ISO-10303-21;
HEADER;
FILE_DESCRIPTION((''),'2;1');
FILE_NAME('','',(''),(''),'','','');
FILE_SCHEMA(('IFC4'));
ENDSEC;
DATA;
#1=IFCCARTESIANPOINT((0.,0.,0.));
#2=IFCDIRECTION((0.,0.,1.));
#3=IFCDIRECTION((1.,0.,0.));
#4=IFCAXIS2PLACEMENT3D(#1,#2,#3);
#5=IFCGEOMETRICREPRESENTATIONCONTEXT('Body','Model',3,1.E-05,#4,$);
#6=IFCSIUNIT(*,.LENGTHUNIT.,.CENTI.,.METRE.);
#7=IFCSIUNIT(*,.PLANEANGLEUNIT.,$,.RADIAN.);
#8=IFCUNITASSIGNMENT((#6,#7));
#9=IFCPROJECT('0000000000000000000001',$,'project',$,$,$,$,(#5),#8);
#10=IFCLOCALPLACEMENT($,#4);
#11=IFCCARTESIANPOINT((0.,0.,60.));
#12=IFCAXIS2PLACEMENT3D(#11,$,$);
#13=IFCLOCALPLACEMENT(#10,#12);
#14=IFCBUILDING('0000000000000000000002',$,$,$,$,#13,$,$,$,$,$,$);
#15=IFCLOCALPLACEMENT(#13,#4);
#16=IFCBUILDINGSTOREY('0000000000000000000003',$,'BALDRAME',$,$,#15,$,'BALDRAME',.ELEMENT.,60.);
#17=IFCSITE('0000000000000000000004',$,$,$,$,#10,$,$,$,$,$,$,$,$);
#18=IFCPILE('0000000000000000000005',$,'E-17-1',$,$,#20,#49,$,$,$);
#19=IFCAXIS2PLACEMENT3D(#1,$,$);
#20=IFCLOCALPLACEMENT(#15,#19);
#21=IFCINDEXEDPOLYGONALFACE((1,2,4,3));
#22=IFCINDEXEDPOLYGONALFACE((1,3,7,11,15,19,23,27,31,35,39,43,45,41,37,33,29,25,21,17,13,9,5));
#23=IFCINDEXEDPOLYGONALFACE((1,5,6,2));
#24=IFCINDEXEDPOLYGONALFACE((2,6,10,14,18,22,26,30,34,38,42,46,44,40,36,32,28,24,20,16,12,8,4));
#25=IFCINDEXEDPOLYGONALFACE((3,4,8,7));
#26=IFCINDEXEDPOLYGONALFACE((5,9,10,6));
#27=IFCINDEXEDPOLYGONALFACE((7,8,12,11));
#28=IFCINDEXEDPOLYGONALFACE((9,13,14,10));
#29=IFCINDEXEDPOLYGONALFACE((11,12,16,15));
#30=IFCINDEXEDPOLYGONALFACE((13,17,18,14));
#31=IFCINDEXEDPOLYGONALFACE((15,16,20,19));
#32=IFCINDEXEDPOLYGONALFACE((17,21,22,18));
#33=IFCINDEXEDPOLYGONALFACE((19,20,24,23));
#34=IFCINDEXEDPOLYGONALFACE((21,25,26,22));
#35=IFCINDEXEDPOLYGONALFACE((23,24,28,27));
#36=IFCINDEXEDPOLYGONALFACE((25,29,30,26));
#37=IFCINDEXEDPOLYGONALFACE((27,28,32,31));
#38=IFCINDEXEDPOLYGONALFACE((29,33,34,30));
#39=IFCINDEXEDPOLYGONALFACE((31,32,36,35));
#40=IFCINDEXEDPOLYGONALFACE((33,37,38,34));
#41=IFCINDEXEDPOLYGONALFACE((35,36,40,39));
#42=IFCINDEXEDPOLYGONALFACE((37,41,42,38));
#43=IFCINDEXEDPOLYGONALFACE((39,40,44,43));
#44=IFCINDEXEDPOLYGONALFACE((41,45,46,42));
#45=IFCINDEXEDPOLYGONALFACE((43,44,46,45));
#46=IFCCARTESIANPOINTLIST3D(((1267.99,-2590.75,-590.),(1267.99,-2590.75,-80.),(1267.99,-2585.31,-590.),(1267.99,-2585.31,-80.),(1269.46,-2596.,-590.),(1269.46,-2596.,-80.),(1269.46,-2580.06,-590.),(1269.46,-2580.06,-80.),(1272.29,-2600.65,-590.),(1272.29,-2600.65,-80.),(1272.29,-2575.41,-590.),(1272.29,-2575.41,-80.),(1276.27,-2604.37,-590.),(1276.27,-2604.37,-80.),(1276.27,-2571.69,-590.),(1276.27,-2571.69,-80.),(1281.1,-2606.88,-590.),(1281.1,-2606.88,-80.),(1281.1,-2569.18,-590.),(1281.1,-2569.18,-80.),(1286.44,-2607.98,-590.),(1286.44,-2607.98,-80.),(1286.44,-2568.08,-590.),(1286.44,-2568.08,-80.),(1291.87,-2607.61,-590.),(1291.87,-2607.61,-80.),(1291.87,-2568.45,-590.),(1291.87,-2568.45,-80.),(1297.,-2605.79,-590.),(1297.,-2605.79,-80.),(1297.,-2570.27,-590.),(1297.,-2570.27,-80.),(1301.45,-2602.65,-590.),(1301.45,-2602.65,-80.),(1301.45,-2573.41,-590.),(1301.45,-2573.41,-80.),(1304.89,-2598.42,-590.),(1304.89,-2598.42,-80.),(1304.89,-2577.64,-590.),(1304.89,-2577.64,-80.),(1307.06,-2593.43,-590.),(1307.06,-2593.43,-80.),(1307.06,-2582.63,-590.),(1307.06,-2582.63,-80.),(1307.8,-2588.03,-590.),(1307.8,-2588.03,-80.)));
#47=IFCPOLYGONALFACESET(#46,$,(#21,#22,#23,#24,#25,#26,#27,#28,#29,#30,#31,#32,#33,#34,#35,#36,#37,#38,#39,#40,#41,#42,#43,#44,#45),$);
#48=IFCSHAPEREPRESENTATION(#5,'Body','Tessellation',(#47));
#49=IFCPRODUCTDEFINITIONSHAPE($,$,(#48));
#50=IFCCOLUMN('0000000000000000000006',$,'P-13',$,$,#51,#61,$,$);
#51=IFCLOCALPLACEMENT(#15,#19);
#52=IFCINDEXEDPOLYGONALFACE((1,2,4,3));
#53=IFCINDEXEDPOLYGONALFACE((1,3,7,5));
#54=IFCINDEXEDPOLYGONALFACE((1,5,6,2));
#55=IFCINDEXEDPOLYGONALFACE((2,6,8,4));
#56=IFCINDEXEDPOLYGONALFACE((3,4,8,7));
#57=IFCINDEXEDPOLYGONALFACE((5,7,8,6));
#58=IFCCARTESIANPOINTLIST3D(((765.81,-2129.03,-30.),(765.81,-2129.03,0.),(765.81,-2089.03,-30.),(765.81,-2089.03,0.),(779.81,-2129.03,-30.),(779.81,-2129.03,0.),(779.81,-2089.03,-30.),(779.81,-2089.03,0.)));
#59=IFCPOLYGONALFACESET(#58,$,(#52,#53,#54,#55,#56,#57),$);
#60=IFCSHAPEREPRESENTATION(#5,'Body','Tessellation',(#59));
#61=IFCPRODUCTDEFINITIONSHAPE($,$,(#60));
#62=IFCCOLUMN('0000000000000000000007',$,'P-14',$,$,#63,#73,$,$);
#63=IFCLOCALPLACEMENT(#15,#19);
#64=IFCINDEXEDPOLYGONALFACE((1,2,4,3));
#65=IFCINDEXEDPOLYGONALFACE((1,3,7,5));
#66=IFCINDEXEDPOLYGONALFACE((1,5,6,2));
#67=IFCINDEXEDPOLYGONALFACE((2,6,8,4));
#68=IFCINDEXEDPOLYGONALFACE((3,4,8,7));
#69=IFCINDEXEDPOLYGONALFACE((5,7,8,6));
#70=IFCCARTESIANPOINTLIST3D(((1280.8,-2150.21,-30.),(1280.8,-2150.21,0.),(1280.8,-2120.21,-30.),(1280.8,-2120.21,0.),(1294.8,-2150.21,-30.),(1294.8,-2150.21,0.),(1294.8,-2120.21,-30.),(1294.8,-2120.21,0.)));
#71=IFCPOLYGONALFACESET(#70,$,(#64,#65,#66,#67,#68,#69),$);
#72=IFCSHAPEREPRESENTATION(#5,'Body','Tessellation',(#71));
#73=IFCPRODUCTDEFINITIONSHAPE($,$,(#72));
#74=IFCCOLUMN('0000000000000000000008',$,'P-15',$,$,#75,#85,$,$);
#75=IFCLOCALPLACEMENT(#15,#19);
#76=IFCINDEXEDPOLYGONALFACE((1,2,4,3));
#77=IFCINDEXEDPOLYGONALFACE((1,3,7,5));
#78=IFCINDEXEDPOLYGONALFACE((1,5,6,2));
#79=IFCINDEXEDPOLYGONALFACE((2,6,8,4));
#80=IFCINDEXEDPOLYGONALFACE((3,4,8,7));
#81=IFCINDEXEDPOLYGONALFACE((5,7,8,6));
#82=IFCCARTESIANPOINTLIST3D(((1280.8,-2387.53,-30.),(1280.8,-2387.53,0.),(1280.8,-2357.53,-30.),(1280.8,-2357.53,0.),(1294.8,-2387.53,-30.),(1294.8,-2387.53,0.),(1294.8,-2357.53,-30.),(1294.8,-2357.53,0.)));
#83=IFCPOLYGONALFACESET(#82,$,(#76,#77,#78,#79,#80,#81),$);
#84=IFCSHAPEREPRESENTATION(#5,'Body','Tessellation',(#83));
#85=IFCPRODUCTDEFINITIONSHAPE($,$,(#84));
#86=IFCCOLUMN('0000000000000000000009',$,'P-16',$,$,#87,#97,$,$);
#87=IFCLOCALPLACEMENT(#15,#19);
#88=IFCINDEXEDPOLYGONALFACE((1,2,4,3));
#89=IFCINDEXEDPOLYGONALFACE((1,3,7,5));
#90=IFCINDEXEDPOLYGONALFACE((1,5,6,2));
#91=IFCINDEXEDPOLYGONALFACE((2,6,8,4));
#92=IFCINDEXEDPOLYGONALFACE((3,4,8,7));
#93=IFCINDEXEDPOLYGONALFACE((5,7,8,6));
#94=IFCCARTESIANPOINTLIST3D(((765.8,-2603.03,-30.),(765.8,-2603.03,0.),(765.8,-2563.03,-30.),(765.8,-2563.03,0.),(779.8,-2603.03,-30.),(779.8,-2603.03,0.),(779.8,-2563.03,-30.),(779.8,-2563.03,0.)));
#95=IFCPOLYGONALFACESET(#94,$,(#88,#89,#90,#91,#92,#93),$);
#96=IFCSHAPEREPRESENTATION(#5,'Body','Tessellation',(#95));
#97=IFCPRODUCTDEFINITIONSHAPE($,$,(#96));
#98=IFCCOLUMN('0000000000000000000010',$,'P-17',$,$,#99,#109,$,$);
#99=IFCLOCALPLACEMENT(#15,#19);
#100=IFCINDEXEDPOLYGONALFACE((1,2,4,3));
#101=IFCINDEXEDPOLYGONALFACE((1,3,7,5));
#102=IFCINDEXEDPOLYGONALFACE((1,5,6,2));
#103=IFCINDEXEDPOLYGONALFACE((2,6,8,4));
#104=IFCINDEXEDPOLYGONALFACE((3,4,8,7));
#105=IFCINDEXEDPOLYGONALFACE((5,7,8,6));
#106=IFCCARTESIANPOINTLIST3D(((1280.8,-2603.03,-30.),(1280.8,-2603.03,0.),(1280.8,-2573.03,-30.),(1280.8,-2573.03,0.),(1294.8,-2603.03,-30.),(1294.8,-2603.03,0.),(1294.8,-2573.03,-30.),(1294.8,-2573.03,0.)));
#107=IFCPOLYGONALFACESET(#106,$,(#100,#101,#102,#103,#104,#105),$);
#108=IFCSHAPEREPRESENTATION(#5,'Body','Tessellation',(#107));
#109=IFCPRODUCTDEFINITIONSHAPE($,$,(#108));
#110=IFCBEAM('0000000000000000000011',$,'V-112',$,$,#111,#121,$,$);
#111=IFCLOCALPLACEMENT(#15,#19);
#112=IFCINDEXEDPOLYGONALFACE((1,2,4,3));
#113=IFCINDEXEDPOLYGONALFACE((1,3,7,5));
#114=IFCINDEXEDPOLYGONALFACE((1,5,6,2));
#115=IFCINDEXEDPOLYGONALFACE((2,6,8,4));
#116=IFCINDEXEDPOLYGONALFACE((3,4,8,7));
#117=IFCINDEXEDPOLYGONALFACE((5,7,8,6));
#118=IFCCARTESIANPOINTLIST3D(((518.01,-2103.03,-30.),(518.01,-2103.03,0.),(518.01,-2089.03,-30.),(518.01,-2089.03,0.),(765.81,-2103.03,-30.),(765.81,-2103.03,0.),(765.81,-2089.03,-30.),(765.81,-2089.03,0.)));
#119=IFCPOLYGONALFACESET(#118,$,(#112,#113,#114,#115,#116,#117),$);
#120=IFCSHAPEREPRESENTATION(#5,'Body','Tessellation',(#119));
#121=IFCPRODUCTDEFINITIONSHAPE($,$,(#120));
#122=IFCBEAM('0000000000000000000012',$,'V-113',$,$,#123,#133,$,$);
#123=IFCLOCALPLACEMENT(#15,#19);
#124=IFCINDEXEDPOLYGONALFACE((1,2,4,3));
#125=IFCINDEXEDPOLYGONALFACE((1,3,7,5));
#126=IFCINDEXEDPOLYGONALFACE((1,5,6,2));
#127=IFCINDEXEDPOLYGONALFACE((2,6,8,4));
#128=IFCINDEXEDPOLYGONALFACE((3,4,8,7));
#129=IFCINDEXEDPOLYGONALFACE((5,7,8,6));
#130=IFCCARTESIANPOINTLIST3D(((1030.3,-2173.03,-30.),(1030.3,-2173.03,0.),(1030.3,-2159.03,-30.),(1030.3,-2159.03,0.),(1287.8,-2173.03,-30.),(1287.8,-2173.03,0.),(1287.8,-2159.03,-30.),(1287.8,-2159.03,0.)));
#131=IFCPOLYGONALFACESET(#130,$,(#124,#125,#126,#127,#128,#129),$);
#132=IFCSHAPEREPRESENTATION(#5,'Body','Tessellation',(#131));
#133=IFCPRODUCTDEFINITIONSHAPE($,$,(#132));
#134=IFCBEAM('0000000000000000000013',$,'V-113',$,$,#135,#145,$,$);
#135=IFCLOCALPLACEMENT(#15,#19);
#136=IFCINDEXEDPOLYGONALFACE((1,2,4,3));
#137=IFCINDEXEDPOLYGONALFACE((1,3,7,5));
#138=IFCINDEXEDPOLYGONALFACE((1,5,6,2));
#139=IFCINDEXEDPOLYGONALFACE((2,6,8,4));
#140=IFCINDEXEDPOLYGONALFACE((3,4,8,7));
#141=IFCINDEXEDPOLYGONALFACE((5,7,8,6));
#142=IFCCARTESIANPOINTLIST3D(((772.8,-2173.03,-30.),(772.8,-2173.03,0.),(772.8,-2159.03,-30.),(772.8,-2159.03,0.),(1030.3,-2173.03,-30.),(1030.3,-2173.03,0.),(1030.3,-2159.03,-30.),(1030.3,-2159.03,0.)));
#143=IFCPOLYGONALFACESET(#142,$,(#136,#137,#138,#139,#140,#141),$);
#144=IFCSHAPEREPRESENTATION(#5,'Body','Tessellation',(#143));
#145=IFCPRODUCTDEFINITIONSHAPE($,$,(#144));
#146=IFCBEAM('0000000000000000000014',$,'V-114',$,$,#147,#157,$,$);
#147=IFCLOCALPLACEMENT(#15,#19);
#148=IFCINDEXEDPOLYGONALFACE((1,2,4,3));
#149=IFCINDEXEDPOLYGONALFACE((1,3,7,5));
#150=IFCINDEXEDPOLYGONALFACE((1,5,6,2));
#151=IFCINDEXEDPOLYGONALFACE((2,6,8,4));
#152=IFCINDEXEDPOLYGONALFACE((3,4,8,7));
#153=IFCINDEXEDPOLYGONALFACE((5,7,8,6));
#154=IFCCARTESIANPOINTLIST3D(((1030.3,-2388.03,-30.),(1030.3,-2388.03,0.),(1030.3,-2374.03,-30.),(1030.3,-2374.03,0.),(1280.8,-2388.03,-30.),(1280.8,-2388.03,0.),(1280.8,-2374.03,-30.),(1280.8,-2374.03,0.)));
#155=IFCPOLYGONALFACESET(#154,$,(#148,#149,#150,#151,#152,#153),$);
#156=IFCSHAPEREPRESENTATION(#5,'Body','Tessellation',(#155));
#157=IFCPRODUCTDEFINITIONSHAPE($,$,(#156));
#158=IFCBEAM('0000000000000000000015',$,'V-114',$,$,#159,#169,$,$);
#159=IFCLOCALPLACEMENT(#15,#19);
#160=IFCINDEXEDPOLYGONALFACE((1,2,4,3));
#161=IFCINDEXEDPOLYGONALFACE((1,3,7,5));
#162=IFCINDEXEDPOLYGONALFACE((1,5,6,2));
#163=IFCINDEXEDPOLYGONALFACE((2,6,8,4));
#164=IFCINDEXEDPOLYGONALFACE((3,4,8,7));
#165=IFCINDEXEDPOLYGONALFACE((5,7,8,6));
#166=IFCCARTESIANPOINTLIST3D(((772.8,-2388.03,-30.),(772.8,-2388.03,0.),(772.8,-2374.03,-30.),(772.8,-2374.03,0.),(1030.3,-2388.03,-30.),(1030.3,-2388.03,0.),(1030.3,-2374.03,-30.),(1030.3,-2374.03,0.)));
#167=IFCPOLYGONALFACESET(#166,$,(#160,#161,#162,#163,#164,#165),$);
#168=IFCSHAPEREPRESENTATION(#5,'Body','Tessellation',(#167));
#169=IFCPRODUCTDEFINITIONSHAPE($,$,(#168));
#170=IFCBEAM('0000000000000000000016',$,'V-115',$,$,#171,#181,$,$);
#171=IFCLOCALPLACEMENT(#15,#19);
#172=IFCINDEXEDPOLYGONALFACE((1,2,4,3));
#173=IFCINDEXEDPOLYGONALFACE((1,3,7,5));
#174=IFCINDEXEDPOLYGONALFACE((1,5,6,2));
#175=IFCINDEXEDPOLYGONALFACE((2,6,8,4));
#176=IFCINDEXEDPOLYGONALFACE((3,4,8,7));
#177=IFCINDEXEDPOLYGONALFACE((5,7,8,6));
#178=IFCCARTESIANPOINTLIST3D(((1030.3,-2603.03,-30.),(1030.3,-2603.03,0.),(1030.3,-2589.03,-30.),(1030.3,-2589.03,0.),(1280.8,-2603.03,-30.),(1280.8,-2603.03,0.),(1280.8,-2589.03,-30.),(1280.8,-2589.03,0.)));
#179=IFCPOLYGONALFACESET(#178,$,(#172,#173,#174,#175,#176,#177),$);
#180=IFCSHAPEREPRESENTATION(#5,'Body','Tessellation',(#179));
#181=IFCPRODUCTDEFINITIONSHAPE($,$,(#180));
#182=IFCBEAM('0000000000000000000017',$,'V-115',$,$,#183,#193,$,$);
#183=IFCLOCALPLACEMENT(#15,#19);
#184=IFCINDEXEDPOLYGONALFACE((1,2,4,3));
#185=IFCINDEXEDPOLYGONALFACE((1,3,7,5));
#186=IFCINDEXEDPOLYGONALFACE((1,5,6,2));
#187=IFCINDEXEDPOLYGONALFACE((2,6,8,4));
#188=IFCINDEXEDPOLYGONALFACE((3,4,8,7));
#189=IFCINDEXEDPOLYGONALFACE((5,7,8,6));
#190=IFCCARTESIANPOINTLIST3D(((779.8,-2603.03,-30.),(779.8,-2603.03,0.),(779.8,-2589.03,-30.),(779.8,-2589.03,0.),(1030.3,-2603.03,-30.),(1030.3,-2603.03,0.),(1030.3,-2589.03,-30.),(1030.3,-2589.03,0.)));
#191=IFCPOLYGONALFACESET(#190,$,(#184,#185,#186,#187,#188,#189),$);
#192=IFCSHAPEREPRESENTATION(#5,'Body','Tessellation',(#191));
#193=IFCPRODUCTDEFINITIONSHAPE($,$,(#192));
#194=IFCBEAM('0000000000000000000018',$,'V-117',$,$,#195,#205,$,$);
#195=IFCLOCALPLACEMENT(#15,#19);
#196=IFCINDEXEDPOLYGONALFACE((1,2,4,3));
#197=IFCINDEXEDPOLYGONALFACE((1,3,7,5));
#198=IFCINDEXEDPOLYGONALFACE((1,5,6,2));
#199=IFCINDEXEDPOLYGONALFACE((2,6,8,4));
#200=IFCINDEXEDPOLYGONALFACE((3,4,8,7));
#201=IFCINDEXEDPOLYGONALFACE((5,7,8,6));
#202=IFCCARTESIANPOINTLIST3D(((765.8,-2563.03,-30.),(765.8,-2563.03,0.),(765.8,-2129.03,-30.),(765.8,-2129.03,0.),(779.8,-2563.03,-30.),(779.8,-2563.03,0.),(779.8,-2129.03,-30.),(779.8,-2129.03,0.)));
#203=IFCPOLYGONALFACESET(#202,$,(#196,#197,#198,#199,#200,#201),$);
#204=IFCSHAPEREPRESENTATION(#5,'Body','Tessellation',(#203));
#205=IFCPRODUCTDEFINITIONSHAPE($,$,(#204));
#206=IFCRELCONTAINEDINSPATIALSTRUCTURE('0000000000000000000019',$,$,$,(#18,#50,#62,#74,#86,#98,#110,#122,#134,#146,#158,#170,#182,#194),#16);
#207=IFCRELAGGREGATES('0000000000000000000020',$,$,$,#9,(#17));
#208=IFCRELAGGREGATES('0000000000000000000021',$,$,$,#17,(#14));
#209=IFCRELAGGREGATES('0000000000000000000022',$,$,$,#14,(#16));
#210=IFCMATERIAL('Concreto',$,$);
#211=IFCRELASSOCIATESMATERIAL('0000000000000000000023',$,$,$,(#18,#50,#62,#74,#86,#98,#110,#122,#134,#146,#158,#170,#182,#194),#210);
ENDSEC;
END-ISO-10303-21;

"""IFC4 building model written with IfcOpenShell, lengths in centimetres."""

from ifc_helpers import new_model, si_unit, frame, origin_with_axes, origin_2d_with_axis, place, context, project, spatial, rectangle, circle, extrude, material, element, save


model = new_model("IFC4")

# Units and contexts
model_context = context("Model", 3, precision=1e-05, world=origin_with_axes(), identifier="Body")
ifc_project = project(units=[si_unit("LENGTHUNIT", "METRE", prefix="CENTI"), si_unit("PLANEANGLEUNIT", "RADIAN")], contexts=[model_context])

# Site, building, storey
site_placement = place(None, origin_with_axes())
site = spatial("IfcSite", under=ifc_project, at=site_placement)
building_placement = place(site_placement, frame((0.0, 0.0, 60.0)))
building = spatial("IfcBuilding", under=site, at=building_placement)
storey_placement = place(building_placement, origin_with_axes())
storey = spatial("IfcBuildingStorey", under=building, at=storey_placement, Name="BALDRAME", LongName="BALDRAME", CompositionType="ELEMENT", Elevation=60.0)

# Pile
ifc_material = material(Name="Concreto")
pile_1_placement = place(storey_placement, frame((1287.8, -2588.03, -80.0), z_axis=(0.0, 0.0, 1.0), x_axis=(1.0, 0.0, 0.0)))
element("IfcPile", 1, at=pile_1_placement, inside=storey, material=ifc_material, Name="E-17-1", context=model_context, shape_type="SweptSolid", body=[
    extrude(circle(Radius=20.0, at=origin_2d_with_axis()), frame((0.0, 0.0, -510.0), z_axis=(0.0, 0.0, 1.0), x_axis=(1.0, 0.0, 0.0)), (0.0, 0.0, 1.0), 510.0),
])

# Columns
column_1_placement = place(storey_placement, frame((772.81, -2109.03, 0.0), z_axis=(0.0, 0.0, 1.0), x_axis=(1.0, 0.0, 0.0)))
element("IfcColumn", 2, at=column_1_placement, inside=storey, material=ifc_material, Name="P-13", context=model_context, shape_type="SolidModel", body=[
    extrude(rectangle(XDim=14.0, YDim=40.0, at=origin_2d_with_axis()), frame((0.0, 0.0, -30.0), z_axis=(0.0, 0.0, 1.0), x_axis=(1.0, 0.0, 0.0)), (0.0, 0.0, 1.0), 30.0),
])
for number, where, z_axis, x_axis, name in (
    (3, (1287.8, -2135.21, 0.0), (0.0, 0.0, 1.0), (1.0, 0.0, 0.0), "P-14"),
    (4, (1287.8, -2372.53, 0.0), (0.0, 0.0, 1.0), (1.0, 0.0, 0.0), "P-15"),
):
    element("IfcColumn", number, at=place(storey_placement, frame(where, z_axis=z_axis, x_axis=x_axis)), inside=storey, material=ifc_material, Name=name, context=model_context, shape_type="SolidModel", body=[
        extrude(rectangle(XDim=14.0, YDim=30.0, at=origin_2d_with_axis()), frame((0.0, 0.0, -30.0), z_axis=(0.0, 0.0, 1.0), x_axis=(1.0, 0.0, 0.0)), (0.0, 0.0, 1.0), 30.0),
    ])
column_2_placement = place(storey_placement, frame((772.8, -2583.03, 0.0), z_axis=(0.0, 0.0, 1.0), x_axis=(1.0, 0.0, 0.0)))
element("IfcColumn", 5, at=column_2_placement, inside=storey, material=ifc_material, Name="P-16", context=model_context, shape_type="SolidModel", body=[
    extrude(rectangle(XDim=14.0, YDim=40.0, at=origin_2d_with_axis()), frame((0.0, 0.0, -30.0), z_axis=(0.0, 0.0, 1.0), x_axis=(1.0, 0.0, 0.0)), (0.0, 0.0, 1.0), 30.0),
])
column_3_placement = place(storey_placement, frame((1287.8, -2588.03, 0.0), z_axis=(0.0, 0.0, 1.0), x_axis=(1.0, 0.0, 0.0)))
element("IfcColumn", 6, at=column_3_placement, inside=storey, material=ifc_material, Name="P-17", context=model_context, shape_type="SolidModel", body=[
    extrude(rectangle(XDim=14.0, YDim=30.0, at=origin_2d_with_axis()), frame((0.0, 0.0, -30.0), z_axis=(0.0, 0.0, 1.0), x_axis=(1.0, 0.0, 0.0)), (0.0, 0.0, 1.0), 30.0),
])

# Beams
beam_1_placement = place(storey_placement, frame((641.91, -2096.03, 0.0), z_axis=(0.0, 0.0, 1.0), x_axis=(1.0, 0.0, 0.0)))
element("IfcBeam", 7, at=beam_1_placement, inside=storey, material=ifc_material, Name="V-112", context=model_context, shape_type="SolidModel", body=[
    extrude(rectangle(XDim=14.0, YDim=30.0, at=origin_2d_with_axis()), frame((-123.9, 0.0, -15.0), z_axis=(1.0, 0.0, 0.0), x_axis=(0.0, -1.0, 0.0)), (0.0, 0.0, 1.0), 247.8),
])
for number, where, z_axis, x_axis, name in (
    (8, (1159.05, -2166.03, 0.0), (0.0, 0.0, 1.0), (1.0, 0.0, 0.0), "V-113"),
    (9, (901.55, -2166.03, 0.0), (0.0, 0.0, 1.0), (1.0, 0.0, 0.0), "V-113"),
):
    element("IfcBeam", number, at=place(storey_placement, frame(where, z_axis=z_axis, x_axis=x_axis)), inside=storey, material=ifc_material, Name=name, context=model_context, shape_type="SolidModel", body=[
        extrude(rectangle(XDim=14.0, YDim=30.0, at=origin_2d_with_axis()), frame((-128.75, 0.0, -15.0), z_axis=(1.0, 0.0, 0.0), x_axis=(0.0, -1.0, 0.0)), (0.0, 0.0, 1.0), 257.5),
    ])
beam_2_placement = place(storey_placement, frame((1155.55, -2381.03, 0.0), z_axis=(0.0, 0.0, 1.0), x_axis=(1.0, 0.0, 0.0)))
element("IfcBeam", 10, at=beam_2_placement, inside=storey, material=ifc_material, Name="V-114", context=model_context, shape_type="SolidModel", body=[
    extrude(rectangle(XDim=14.0, YDim=30.0, at=origin_2d_with_axis()), frame((-125.25, 0.0, -15.0), z_axis=(1.0, 0.0, 0.0), x_axis=(0.0, -1.0, 0.0)), (0.0, 0.0, 1.0), 250.5),
])
beam_3_placement = place(storey_placement, frame((901.55, -2381.03, 0.0), z_axis=(0.0, 0.0, 1.0), x_axis=(1.0, 0.0, 0.0)))
element("IfcBeam", 11, at=beam_3_placement, inside=storey, material=ifc_material, Name="V-114", context=model_context, shape_type="SolidModel", body=[
    extrude(rectangle(XDim=14.0, YDim=30.0, at=origin_2d_with_axis()), frame((-128.75, 0.0, -15.0), z_axis=(1.0, 0.0, 0.0), x_axis=(0.0, -1.0, 0.0)), (0.0, 0.0, 1.0), 257.5),
])
for number, where, z_axis, x_axis, name in (
    (12, (1155.55, -2596.03, 0.0), (0.0, 0.0, 1.0), (1.0, 0.0, 0.0), "V-115"),
    (13, (905.05, -2596.03, 0.0), (0.0, 0.0, 1.0), (1.0, 0.0, 0.0), "V-115"),
):
    element("IfcBeam", number, at=place(storey_placement, frame(where, z_axis=z_axis, x_axis=x_axis)), inside=storey, material=ifc_material, Name=name, context=model_context, shape_type="SolidModel", body=[
        extrude(rectangle(XDim=14.0, YDim=30.0, at=origin_2d_with_axis()), frame((-125.25, 0.0, -15.0), z_axis=(1.0, 0.0, 0.0), x_axis=(0.0, -1.0, 0.0)), (0.0, 0.0, 1.0), 250.5),
    ])
beam_4_placement = place(storey_placement, frame((772.8, -2346.03, 0.0), z_axis=(0.0, 0.0, 1.0), x_axis=(1.0, 0.0, 0.0)))
element("IfcBeam", 14, at=beam_4_placement, inside=storey, material=ifc_material, Name="V-117", context=model_context, shape_type="SolidModel", body=[
    extrude(rectangle(XDim=14.0, YDim=30.0, at=origin_2d_with_axis()), frame((0.0, -217.0, -15.0), z_axis=(0.0, 1.0, 0.0), x_axis=(1.0, 0.0, 0.0)), (0.0, 0.0, 1.0), 434.0),
])

save(model, "model.ifc")
